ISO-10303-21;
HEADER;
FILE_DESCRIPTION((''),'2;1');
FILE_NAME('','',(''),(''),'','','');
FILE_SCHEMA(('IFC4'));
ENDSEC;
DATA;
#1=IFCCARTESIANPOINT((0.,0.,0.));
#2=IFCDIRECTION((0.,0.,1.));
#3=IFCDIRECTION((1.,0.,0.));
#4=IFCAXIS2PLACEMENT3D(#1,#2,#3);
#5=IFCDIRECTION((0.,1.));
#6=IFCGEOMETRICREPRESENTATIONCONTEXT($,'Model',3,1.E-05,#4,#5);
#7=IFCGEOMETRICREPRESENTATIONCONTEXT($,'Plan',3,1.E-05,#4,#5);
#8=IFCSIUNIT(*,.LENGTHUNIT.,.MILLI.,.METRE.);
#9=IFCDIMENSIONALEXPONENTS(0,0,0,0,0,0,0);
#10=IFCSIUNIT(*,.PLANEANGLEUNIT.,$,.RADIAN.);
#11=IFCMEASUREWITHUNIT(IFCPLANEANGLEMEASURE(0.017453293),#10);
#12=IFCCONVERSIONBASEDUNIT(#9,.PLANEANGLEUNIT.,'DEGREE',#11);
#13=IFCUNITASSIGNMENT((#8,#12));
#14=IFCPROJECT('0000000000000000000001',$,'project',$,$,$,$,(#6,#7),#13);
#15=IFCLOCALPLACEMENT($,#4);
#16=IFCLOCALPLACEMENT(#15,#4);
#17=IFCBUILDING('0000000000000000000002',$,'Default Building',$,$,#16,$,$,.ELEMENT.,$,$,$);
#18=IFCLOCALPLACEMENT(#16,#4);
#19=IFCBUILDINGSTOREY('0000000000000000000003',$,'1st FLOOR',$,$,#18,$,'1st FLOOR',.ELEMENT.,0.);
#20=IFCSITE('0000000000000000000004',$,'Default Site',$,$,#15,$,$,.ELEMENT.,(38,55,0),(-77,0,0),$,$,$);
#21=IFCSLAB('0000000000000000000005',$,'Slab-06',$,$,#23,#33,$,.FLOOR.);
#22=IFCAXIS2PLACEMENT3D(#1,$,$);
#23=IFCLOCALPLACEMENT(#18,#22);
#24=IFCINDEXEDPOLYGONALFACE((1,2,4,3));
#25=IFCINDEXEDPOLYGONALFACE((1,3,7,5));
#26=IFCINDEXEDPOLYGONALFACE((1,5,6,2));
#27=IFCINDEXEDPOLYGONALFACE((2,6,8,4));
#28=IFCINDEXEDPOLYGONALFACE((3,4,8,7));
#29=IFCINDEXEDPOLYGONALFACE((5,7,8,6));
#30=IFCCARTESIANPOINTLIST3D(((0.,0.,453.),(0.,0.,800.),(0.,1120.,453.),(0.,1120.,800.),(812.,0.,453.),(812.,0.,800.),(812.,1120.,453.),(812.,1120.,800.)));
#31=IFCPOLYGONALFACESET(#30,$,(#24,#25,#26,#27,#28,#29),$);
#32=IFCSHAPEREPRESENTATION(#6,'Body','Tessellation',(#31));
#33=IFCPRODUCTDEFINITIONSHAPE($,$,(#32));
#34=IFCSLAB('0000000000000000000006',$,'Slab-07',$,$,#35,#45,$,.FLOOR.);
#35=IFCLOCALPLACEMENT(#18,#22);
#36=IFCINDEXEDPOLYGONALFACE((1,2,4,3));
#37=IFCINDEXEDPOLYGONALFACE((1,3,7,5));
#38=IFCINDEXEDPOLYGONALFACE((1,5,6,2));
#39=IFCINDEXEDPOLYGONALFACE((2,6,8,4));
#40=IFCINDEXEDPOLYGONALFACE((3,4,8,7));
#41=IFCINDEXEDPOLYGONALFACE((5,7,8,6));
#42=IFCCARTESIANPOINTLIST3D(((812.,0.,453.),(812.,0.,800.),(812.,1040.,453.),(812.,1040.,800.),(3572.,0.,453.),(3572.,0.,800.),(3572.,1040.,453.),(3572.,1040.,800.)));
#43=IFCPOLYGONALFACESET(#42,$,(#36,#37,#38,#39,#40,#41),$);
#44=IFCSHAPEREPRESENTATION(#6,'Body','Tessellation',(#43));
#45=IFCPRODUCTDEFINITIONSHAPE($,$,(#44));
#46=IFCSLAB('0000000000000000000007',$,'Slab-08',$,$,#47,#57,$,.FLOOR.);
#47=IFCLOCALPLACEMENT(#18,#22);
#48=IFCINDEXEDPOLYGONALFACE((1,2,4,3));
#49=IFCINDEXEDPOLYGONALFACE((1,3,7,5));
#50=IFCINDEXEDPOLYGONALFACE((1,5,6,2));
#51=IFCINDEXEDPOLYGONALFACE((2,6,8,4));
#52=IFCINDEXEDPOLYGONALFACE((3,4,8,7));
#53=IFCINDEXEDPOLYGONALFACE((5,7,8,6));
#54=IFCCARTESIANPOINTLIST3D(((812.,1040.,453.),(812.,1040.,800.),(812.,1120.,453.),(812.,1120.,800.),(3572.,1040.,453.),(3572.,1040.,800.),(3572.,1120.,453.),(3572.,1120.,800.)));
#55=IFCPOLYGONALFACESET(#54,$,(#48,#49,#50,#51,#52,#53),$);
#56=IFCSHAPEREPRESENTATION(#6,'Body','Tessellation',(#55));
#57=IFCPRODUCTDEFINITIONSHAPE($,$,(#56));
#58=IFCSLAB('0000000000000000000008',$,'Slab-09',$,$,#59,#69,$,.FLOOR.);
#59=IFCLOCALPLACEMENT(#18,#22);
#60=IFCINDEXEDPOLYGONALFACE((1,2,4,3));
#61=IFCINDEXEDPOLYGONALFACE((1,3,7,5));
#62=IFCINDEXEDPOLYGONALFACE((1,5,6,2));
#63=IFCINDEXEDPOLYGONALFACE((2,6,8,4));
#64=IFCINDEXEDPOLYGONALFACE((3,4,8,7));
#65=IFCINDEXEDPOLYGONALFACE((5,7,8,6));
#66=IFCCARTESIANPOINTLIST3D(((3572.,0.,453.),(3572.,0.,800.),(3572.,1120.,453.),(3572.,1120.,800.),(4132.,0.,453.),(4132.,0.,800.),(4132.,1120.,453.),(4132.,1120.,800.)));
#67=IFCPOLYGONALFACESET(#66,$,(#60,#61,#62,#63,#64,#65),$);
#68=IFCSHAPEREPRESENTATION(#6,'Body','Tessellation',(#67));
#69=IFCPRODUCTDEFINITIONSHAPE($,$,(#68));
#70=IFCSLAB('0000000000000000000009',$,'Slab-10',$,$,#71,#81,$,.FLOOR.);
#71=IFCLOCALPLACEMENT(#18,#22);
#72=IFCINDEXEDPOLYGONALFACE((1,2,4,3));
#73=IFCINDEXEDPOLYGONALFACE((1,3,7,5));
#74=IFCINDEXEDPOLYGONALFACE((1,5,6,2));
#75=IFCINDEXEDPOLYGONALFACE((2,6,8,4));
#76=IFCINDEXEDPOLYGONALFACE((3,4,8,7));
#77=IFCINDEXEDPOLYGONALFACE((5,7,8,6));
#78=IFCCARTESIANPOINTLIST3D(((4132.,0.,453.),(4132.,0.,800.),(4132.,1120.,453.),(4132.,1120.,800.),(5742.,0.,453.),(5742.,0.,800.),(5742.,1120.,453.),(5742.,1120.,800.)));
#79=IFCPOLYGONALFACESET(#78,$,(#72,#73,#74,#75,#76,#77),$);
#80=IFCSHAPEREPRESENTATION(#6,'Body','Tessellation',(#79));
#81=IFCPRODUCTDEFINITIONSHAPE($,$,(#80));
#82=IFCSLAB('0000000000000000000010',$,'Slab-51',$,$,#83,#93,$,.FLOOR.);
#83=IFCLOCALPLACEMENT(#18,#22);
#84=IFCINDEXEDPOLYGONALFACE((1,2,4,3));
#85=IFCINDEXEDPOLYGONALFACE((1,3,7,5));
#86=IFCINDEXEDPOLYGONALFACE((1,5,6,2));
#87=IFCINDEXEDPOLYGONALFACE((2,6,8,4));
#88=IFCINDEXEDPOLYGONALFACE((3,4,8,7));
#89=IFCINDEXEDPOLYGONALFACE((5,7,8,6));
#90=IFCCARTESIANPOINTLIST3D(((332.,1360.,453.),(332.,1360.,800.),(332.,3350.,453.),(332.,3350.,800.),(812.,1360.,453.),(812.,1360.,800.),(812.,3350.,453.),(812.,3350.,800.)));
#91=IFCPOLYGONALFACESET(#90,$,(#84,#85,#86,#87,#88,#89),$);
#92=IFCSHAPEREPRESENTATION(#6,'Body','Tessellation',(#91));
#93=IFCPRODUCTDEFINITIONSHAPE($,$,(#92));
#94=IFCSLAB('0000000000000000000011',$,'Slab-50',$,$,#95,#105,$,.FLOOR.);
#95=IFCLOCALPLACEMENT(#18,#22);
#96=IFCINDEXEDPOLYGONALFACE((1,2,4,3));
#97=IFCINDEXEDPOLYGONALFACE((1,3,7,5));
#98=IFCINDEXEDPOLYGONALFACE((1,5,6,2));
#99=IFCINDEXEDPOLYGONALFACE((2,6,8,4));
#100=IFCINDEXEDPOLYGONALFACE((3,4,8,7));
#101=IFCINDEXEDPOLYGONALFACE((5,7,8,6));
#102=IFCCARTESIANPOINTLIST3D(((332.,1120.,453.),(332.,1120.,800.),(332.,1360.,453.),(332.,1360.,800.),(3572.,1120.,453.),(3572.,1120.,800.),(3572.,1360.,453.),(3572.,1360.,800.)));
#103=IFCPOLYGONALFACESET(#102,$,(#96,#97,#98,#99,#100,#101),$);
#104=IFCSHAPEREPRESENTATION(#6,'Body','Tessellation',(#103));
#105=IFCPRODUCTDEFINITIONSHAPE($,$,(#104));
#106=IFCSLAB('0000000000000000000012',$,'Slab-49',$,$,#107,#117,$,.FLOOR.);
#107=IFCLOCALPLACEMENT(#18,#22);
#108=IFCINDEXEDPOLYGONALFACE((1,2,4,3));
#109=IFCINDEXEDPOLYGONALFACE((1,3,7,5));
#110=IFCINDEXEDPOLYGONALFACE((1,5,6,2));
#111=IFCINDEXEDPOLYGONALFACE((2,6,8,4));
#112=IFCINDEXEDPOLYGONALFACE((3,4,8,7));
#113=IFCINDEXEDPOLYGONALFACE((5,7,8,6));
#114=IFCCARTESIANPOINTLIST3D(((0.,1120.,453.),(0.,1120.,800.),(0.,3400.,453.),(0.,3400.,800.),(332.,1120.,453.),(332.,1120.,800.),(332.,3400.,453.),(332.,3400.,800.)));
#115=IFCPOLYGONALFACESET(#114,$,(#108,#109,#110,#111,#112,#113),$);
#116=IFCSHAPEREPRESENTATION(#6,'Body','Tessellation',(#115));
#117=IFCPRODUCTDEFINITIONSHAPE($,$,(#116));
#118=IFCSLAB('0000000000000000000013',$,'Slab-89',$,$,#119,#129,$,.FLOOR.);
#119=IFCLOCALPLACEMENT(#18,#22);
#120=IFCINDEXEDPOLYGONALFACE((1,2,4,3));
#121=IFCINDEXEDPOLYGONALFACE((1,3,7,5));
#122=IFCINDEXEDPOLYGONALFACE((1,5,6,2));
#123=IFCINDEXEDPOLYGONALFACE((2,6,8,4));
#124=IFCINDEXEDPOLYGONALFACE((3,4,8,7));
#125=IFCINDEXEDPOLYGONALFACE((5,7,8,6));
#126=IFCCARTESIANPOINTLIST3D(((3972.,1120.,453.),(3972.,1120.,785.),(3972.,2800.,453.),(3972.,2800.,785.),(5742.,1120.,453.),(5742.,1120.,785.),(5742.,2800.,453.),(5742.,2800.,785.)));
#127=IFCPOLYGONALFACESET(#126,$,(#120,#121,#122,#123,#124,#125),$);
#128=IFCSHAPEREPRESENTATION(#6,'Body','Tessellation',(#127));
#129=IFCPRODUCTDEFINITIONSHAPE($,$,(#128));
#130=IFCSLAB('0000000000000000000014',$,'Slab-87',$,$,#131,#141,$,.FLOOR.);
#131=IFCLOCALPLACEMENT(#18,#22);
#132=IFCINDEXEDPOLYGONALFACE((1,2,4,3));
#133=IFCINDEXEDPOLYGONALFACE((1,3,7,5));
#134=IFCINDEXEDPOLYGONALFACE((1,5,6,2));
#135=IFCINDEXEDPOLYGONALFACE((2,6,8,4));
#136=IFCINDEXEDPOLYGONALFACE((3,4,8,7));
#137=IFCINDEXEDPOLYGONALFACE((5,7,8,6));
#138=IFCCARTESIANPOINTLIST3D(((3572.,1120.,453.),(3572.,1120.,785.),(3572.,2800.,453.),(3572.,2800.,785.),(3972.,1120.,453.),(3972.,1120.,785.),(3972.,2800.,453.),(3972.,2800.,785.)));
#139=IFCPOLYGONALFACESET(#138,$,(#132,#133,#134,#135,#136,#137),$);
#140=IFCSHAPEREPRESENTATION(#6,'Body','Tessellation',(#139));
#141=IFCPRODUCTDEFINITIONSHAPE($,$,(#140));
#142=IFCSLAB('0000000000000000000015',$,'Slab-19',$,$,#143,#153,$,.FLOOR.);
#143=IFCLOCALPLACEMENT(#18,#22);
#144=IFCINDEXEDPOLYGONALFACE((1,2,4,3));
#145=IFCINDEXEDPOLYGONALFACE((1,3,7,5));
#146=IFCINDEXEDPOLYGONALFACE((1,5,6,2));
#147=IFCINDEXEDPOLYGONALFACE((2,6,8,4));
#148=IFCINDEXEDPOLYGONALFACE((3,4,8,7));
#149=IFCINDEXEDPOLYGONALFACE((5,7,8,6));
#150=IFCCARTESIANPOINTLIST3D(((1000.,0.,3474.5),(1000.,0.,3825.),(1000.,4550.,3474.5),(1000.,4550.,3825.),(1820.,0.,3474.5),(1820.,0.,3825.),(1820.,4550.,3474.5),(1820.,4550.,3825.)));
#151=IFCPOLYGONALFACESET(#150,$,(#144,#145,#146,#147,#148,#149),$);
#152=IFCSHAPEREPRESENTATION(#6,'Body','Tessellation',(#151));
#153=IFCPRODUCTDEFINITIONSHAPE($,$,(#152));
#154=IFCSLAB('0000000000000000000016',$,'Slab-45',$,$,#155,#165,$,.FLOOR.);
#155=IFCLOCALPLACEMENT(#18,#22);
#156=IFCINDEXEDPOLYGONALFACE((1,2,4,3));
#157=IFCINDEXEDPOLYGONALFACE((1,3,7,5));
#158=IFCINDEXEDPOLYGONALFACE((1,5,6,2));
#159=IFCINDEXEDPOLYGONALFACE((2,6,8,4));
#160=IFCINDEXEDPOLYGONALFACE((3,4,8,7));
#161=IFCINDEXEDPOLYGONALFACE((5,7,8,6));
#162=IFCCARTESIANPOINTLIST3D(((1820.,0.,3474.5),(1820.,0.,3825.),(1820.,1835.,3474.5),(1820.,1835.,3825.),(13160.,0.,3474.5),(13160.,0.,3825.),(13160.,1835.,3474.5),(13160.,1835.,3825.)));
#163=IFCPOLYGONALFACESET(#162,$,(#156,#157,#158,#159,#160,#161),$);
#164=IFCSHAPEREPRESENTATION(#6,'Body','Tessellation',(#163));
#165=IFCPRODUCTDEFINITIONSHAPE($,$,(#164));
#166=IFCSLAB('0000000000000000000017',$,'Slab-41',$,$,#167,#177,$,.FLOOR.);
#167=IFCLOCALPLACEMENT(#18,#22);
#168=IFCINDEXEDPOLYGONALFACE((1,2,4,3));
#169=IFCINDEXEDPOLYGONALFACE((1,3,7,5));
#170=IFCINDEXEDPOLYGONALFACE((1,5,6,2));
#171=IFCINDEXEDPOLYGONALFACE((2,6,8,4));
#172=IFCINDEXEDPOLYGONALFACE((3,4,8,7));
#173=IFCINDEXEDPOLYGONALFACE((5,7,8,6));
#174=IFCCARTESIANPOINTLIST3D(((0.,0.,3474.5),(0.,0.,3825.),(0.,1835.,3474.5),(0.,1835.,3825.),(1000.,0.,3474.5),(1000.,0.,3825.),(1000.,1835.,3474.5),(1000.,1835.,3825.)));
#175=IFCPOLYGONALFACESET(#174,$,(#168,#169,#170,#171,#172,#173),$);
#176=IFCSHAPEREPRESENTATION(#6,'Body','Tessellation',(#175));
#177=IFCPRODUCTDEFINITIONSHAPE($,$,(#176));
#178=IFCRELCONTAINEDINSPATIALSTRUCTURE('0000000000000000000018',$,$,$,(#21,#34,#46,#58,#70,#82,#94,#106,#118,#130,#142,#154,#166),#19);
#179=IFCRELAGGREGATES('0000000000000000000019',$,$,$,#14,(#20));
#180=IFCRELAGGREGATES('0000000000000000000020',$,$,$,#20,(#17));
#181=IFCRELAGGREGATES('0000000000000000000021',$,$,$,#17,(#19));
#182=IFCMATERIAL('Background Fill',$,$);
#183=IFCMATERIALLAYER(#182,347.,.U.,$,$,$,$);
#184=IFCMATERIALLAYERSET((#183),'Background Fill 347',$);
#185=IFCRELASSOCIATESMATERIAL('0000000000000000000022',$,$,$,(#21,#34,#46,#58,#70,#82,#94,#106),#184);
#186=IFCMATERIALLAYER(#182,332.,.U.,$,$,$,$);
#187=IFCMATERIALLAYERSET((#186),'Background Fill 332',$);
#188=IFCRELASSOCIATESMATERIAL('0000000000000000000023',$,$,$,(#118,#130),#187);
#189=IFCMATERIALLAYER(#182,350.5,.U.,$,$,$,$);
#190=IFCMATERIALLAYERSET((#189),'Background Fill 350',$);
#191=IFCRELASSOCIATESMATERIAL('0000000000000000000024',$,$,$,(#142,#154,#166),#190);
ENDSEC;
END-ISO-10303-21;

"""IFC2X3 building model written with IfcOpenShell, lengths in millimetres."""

from ifc_helpers import new_model, entity, si_unit, converted_unit, direction, frame, origin_with_axes, place, context, project, spatial, polyline, outline, extrude, material, layer, layer_set, layer_usage, element, save


model = new_model("IFC2X3")

# Units and contexts
model_context = context("Model", 3, precision=1e-05, world=origin_with_axes(), true_north=direction((0.0, 1.0)))
plan_context = context("Plan", 3, precision=1e-05, world=origin_with_axes(), true_north=direction((0.0, 1.0)))
ifc_project = project(units=[si_unit("LENGTHUNIT", "METRE", prefix="MILLI"), converted_unit("PLANEANGLEUNIT", "DEGREE", entity("IfcPlaneAngleMeasure", 0.017453293), si_unit("PLANEANGLEUNIT", "RADIAN"), dimensions=[0, 0, 0, 0, 0, 0, 0])], contexts=[model_context, plan_context])

# Site, building, storey
site_placement = place(None, origin_with_axes())
site = spatial("IfcSite", under=ifc_project, at=site_placement, Name="Default Site", CompositionType="ELEMENT", RefLatitude=(38, 55, 0), RefLongitude=(-77, 0, 0))
building_placement = place(site_placement, origin_with_axes())
building = spatial("IfcBuilding", under=site, at=building_placement, Name="Default Building", CompositionType="ELEMENT")
storey_placement = place(building_placement, origin_with_axes())
storey = spatial("IfcBuildingStorey", under=building, at=storey_placement, Name="1st FLOOR", LongName="1st FLOOR", CompositionType="ELEMENT", Elevation=0.0)

# Slabs
ifc_material = material(Name="Background Fill")
ifc_layer_1 = layer(ifc_material, 347.0, ventilated="UNKNOWN")
ifc_layer_set_1 = layer_set([ifc_layer_1], Name="Background Fill 347")
ifc_layer_usage_1 = layer_usage(ifc_layer_set_1, "AXIS3", "NEGATIVE", 347.0)
slab_1_placement = place(storey_placement, frame((0.0, 0.0, 453.0), z_axis=(0.0, 0.0, 1.0), x_axis=(1.0, 0.0, 0.0)))
element("IfcSlab", 1, at=slab_1_placement, inside=storey, material=ifc_layer_usage_1, Name="Slab-06", PredefinedType="FLOOR", context=model_context, shape_type="SweptSolid", body=[
    extrude(outline(polyline([(0.0, 0.0), (812.0, 0.0), (812.0, 1120.0), (0.0, 1120.0), (0.0, 0.0)])), origin_with_axes(), (0.0, 0.0, 1.0), 347.0),
])
ifc_layer_usage_2 = layer_usage(ifc_layer_set_1, "AXIS3", "NEGATIVE", 347.0)
slab_2_placement = place(storey_placement, frame((812.0, 0.0, 453.0), z_axis=(0.0, 0.0, 1.0), x_axis=(1.0, 0.0, 0.0)))
element("IfcSlab", 2, at=slab_2_placement, inside=storey, material=ifc_layer_usage_2, Name="Slab-07", PredefinedType="FLOOR", context=model_context, shape_type="SweptSolid", body=[
    extrude(outline(polyline([(0.0, 0.0), (2760.0, 0.0), (2760.0, 1040.0), (0.0, 1040.0), (0.0, 0.0)])), origin_with_axes(), (0.0, 0.0, 1.0), 347.0),
])
ifc_layer_usage_3 = layer_usage(ifc_layer_set_1, "AXIS3", "NEGATIVE", 347.0)
slab_3_placement = place(storey_placement, frame((812.0, 1040.0, 453.0), z_axis=(0.0, 0.0, 1.0), x_axis=(1.0, 0.0, 0.0)))
element("IfcSlab", 3, at=slab_3_placement, inside=storey, material=ifc_layer_usage_3, Name="Slab-08", PredefinedType="FLOOR", context=model_context, shape_type="SweptSolid", body=[
    extrude(outline(polyline([(0.0, 0.0), (2760.0, 0.0), (2760.0, 80.0), (0.0, 80.0), (0.0, 0.0)])), origin_with_axes(), (0.0, 0.0, 1.0), 347.0),
])
ifc_layer_usage_4 = layer_usage(ifc_layer_set_1, "AXIS3", "NEGATIVE", 347.0)
slab_4_placement = place(storey_placement, frame((3572.0, 0.0, 453.0), z_axis=(0.0, 0.0, 1.0), x_axis=(1.0, 0.0, 0.0)))
element("IfcSlab", 4, at=slab_4_placement, inside=storey, material=ifc_layer_usage_4, Name="Slab-09", PredefinedType="FLOOR", context=model_context, shape_type="SweptSolid", body=[
    extrude(outline(polyline([(0.0, 0.0), (560.0, 0.0), (560.0, 1120.0), (0.0, 1120.0), (0.0, 0.0)])), origin_with_axes(), (0.0, 0.0, 1.0), 347.0),
])
ifc_layer_usage_5 = layer_usage(ifc_layer_set_1, "AXIS3", "NEGATIVE", 347.0)
slab_5_placement = place(storey_placement, frame((4132.0, 0.0, 453.0), z_axis=(0.0, 0.0, 1.0), x_axis=(1.0, 0.0, 0.0)))
element("IfcSlab", 5, at=slab_5_placement, inside=storey, material=ifc_layer_usage_5, Name="Slab-10", PredefinedType="FLOOR", context=model_context, shape_type="SweptSolid", body=[
    extrude(outline(polyline([(0.0, 0.0), (1610.0, 0.0), (1610.0, 1120.0), (0.0, 1120.0), (0.0, 0.0)])), origin_with_axes(), (0.0, 0.0, 1.0), 347.0),
])
ifc_layer_usage_6 = layer_usage(ifc_layer_set_1, "AXIS3", "NEGATIVE", 347.0)
slab_6_placement = place(storey_placement, frame((332.0, 1360.0, 453.0), z_axis=(0.0, 0.0, 1.0), x_axis=(1.0, 0.0, 0.0)))
element("IfcSlab", 6, at=slab_6_placement, inside=storey, material=ifc_layer_usage_6, Name="Slab-51", PredefinedType="FLOOR", context=model_context, shape_type="SweptSolid", body=[
    extrude(outline(polyline([(0.0, 0.0), (480.0, 0.0), (480.0, 1990.0), (0.0, 1990.0), (0.0, 0.0)])), origin_with_axes(), (0.0, 0.0, 1.0), 347.0),
])
ifc_layer_usage_7 = layer_usage(ifc_layer_set_1, "AXIS3", "NEGATIVE", 347.0)
slab_7_placement = place(storey_placement, frame((332.0, 1120.0, 453.0), z_axis=(0.0, 0.0, 1.0), x_axis=(1.0, 0.0, 0.0)))
element("IfcSlab", 7, at=slab_7_placement, inside=storey, material=ifc_layer_usage_7, Name="Slab-50", PredefinedType="FLOOR", context=model_context, shape_type="SweptSolid", body=[
    extrude(outline(polyline([(0.0, 0.0), (3240.0, 0.0), (3240.0, 240.0), (0.0, 240.0), (0.0, 0.0)])), origin_with_axes(), (0.0, 0.0, 1.0), 347.0),
])
ifc_layer_usage_8 = layer_usage(ifc_layer_set_1, "AXIS3", "NEGATIVE", 347.0)
slab_8_placement = place(storey_placement, frame((0.0, 1120.0, 453.0), z_axis=(0.0, 0.0, 1.0), x_axis=(1.0, 0.0, 0.0)))
element("IfcSlab", 8, at=slab_8_placement, inside=storey, material=ifc_layer_usage_8, Name="Slab-49", PredefinedType="FLOOR", context=model_context, shape_type="SweptSolid", body=[
    extrude(outline(polyline([(0.0, 0.0), (332.0, 0.0), (332.0, 2280.0), (0.0, 2280.0), (0.0, 0.0)])), origin_with_axes(), (0.0, 0.0, 1.0), 347.0),
])
ifc_layer_2 = layer(ifc_material, 332.0, ventilated="UNKNOWN")
ifc_layer_set_2 = layer_set([ifc_layer_2], Name="Background Fill 332")
ifc_layer_usage_9 = layer_usage(ifc_layer_set_2, "AXIS3", "NEGATIVE", 332.0)
slab_9_placement = place(storey_placement, frame((3972.0, 1120.0, 453.0), z_axis=(0.0, 0.0, 1.0), x_axis=(1.0, 0.0, 0.0)))
element("IfcSlab", 9, at=slab_9_placement, inside=storey, material=ifc_layer_usage_9, Name="Slab-89", PredefinedType="FLOOR", context=model_context, shape_type="SweptSolid", body=[
    extrude(outline(polyline([(0.0, 0.0), (1770.0, 0.0), (1770.0, 1680.0), (0.0, 1680.0), (0.0, 0.0)])), origin_with_axes(), (0.0, 0.0, 1.0), 332.0),
])
ifc_layer_usage_10 = layer_usage(ifc_layer_set_2, "AXIS3", "NEGATIVE", 332.0)
slab_10_placement = place(storey_placement, frame((3572.0, 1120.0, 453.0), z_axis=(0.0, 0.0, 1.0), x_axis=(1.0, 0.0, 0.0)))
element("IfcSlab", 10, at=slab_10_placement, inside=storey, material=ifc_layer_usage_10, Name="Slab-87", PredefinedType="FLOOR", context=model_context, shape_type="SweptSolid", body=[
    extrude(outline(polyline([(0.0, 0.0), (400.0, 0.0), (400.0, 1680.0), (0.0, 1680.0), (0.0, 0.0)])), origin_with_axes(), (0.0, 0.0, 1.0), 332.0),
])
ifc_layer_3 = layer(ifc_material, 350.5, ventilated="UNKNOWN")
ifc_layer_set_3 = layer_set([ifc_layer_3], Name="Background Fill 350")
ifc_layer_usage_11 = layer_usage(ifc_layer_set_3, "AXIS3", "NEGATIVE", 350.5)
slab_11_placement = place(storey_placement, frame((1000.0, 0.0, 3474.5), z_axis=(0.0, 0.0, 1.0), x_axis=(1.0, 0.0, 0.0)))
element("IfcSlab", 11, at=slab_11_placement, inside=storey, material=ifc_layer_usage_11, Name="Slab-19", PredefinedType="FLOOR", context=model_context, shape_type="SweptSolid", body=[
    extrude(outline(polyline([(0.0, 0.0), (820.0, 0.0), (820.0, 4550.0), (0.0, 4550.0), (0.0, 0.0)])), origin_with_axes(), (0.0, 0.0, 1.0), 350.5),
])
ifc_layer_usage_12 = layer_usage(ifc_layer_set_3, "AXIS3", "NEGATIVE", 350.5)
slab_12_placement = place(storey_placement, frame((1820.0, 0.0, 3474.5), z_axis=(0.0, 0.0, 1.0), x_axis=(1.0, 0.0, 0.0)))
element("IfcSlab", 12, at=slab_12_placement, inside=storey, material=ifc_layer_usage_12, Name="Slab-45", PredefinedType="FLOOR", context=model_context, shape_type="SweptSolid", body=[
    extrude(outline(polyline([(0.0, 0.0), (11340.0, 0.0), (11340.0, 1835.0), (0.0, 1835.0), (0.0, 0.0)])), origin_with_axes(), (0.0, 0.0, 1.0), 350.5),
])
ifc_layer_usage_13 = layer_usage(ifc_layer_set_3, "AXIS3", "NEGATIVE", 350.5)
slab_13_placement = place(storey_placement, frame((0.0, 0.0, 3474.5), z_axis=(0.0, 0.0, 1.0), x_axis=(1.0, 0.0, 0.0)))
element("IfcSlab", 13, at=slab_13_placement, inside=storey, material=ifc_layer_usage_13, Name="Slab-41", PredefinedType="FLOOR", context=model_context, shape_type="SweptSolid", body=[
    extrude(outline(polyline([(0.0, 0.0), (1000.0, 0.0), (1000.0, 1835.0), (0.0, 1835.0), (0.0, 0.0)])), origin_with_axes(), (0.0, 0.0, 1.0), 350.5),
])

save(model, "model.ifc")
